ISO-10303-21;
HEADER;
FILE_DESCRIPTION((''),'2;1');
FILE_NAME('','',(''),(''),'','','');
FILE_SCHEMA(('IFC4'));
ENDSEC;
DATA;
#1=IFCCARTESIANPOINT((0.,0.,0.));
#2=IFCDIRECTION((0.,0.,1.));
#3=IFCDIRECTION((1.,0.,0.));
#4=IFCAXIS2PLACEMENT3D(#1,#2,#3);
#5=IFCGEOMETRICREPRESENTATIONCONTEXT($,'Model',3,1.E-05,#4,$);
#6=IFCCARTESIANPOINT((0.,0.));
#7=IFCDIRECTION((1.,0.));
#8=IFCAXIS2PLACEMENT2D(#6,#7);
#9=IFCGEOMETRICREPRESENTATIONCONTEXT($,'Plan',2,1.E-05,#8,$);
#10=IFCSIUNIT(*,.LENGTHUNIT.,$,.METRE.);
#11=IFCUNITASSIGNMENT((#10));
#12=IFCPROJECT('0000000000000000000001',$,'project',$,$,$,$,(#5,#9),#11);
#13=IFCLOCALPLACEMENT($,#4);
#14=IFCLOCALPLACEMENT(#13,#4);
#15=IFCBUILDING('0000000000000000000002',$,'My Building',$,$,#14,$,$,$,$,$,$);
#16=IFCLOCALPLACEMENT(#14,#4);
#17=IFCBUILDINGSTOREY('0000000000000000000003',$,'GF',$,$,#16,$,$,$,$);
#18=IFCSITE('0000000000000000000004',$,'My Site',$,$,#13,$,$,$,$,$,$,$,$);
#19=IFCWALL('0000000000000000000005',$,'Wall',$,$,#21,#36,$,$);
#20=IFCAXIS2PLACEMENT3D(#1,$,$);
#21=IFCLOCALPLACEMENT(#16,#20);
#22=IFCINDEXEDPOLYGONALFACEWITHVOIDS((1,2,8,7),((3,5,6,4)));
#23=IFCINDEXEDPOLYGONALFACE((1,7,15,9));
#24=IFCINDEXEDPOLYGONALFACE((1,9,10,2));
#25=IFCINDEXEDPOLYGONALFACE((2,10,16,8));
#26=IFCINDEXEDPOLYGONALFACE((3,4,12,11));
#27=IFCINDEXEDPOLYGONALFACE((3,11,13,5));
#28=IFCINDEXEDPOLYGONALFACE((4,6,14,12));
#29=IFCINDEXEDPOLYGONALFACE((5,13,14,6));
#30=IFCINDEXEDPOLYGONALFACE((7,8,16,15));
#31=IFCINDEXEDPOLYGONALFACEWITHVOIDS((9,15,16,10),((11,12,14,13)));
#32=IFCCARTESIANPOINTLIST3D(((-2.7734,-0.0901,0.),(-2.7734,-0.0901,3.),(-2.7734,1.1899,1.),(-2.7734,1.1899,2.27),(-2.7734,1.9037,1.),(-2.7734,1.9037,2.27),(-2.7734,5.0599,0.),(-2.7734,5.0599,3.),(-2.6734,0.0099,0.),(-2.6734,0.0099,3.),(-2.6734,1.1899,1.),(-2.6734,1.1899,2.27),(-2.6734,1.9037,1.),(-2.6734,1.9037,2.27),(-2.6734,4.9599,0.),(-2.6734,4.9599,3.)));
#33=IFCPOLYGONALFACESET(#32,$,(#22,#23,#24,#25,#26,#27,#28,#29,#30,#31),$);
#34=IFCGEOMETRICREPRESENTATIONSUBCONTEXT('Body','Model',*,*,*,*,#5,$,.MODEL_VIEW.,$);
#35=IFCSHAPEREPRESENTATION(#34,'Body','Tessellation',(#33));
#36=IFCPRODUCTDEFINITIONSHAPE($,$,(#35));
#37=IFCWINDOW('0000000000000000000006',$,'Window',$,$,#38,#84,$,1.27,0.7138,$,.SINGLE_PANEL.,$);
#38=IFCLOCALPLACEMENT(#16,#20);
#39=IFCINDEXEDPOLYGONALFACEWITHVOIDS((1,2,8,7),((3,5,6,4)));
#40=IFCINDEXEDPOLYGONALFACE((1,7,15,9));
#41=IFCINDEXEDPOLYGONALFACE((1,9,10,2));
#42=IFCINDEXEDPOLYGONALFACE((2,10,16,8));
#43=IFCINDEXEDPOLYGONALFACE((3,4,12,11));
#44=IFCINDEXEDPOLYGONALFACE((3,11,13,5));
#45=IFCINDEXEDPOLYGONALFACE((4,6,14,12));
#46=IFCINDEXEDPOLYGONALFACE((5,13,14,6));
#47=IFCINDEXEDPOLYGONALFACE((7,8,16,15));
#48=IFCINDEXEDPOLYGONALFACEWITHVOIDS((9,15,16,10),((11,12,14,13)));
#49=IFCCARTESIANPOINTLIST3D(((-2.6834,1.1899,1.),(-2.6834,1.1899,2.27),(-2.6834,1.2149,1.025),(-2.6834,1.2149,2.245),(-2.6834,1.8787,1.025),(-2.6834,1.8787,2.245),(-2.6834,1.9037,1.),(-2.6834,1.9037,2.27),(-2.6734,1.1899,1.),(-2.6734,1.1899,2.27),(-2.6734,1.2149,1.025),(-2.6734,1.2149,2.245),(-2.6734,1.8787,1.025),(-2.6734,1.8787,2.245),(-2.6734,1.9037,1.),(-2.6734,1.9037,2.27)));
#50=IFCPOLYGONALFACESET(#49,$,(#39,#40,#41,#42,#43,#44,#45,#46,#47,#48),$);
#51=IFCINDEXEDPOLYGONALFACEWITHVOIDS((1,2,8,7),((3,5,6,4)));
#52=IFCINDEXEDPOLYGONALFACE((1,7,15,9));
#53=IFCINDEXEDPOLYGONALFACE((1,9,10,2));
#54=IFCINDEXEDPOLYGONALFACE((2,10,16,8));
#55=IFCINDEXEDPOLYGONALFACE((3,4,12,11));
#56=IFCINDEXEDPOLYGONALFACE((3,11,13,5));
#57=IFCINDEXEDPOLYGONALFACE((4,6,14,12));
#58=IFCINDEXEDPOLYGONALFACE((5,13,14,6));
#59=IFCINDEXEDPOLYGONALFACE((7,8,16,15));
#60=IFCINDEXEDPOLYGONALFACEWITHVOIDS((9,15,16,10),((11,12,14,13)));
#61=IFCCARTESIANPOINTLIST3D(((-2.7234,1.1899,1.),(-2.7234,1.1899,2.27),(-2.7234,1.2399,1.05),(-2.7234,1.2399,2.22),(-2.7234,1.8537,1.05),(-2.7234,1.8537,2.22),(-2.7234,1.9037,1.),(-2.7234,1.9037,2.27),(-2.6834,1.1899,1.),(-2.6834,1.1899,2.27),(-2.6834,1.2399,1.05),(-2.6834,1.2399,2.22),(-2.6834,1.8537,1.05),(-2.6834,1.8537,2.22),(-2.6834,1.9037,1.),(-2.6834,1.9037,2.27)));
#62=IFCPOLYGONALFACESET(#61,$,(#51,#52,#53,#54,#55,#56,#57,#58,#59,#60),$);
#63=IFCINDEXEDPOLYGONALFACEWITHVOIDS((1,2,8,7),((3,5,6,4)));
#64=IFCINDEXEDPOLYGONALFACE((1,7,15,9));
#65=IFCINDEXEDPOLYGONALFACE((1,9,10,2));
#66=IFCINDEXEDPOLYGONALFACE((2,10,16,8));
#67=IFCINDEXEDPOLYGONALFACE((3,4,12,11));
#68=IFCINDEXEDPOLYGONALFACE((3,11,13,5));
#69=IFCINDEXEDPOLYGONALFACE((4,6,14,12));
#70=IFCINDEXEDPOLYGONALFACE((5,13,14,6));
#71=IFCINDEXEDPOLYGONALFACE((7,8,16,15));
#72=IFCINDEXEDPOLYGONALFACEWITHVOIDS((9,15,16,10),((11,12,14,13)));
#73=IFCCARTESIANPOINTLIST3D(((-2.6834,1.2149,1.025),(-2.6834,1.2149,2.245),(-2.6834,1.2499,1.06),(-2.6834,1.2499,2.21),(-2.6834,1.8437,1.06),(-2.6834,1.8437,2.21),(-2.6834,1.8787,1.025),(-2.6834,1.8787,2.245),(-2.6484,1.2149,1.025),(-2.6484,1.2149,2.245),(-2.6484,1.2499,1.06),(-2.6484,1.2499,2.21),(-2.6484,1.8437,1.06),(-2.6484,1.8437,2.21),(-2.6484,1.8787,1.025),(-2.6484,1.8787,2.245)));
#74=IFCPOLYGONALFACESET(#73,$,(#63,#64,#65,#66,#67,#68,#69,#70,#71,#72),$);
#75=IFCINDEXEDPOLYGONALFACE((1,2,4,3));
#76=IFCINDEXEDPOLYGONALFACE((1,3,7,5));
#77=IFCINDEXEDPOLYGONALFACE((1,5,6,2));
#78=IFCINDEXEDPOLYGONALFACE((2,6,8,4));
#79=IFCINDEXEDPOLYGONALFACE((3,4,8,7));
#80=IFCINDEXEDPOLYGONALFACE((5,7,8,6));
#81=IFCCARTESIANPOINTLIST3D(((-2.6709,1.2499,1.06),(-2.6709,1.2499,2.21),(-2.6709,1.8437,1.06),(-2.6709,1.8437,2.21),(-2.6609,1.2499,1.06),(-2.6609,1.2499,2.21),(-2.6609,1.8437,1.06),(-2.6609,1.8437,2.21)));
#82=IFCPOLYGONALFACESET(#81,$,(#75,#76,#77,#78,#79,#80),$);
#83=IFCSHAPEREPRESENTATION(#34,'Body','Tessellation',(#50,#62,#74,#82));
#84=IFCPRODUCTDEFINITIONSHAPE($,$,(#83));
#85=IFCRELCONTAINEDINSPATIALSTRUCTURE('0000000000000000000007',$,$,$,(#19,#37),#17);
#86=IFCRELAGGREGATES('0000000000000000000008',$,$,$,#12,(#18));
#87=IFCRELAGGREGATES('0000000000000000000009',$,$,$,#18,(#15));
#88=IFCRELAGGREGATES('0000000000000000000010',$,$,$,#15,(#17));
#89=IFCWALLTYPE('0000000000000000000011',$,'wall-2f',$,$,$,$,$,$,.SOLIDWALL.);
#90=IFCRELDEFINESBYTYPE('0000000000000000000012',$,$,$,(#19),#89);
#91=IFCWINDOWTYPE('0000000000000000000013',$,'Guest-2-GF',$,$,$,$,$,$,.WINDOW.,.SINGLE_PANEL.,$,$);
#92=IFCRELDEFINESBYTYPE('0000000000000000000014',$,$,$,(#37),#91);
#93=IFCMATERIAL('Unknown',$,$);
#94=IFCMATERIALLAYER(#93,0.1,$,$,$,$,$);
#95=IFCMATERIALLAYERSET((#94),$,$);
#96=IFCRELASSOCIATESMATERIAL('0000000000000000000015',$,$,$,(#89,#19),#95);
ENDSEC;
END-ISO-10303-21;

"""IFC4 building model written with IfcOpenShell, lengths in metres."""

from ifc_helpers import new_model, entity, si_unit, frame, origin_with_axes, origin_2d_with_axis, place, context, subcontext, project, spatial, line, indexed_curve, outline, extrude, shape, source, transform, mapped, material, layer, layer_set, layer_usage, type_object, type_shapes, element, fill, save


model = new_model("IFC4")

# Units and contexts
model_context = context("Model", 3, precision=1e-05, world=origin_with_axes())
plan_context = context("Plan", 2, precision=1e-05, world=origin_2d_with_axis())
body_context_1 = subcontext(model_context, "Body", "Model", "MODEL_VIEW")
body_context_2 = subcontext(plan_context, "Body", "Plan", "PLAN_VIEW")
ifc_project = project(units=[si_unit("LENGTHUNIT", "METRE")], contexts=[model_context, plan_context])

# Site, building, storey
site_placement = place(None, origin_with_axes())
site = spatial("IfcSite", under=ifc_project, at=site_placement, Name="My Site")
building_placement = place(site_placement, origin_with_axes())
building = spatial("IfcBuilding", under=site, at=building_placement, Name="My Building")
storey_placement = place(building_placement, origin_with_axes())
storey = spatial("IfcBuildingStorey", under=building, at=storey_placement, Name="GF")

# Shared definitions
ifc_material = material(Name="Unknown")

# Shared definitions
ifc_layer_1 = layer(ifc_material, 0.1)
ifc_layer_set_1 = layer_set([ifc_layer_1])
wall_type = type_object("IfcWallType", Name="wall-2f", PredefinedType="SOLIDWALL", material=ifc_layer_set_1)

# Wall, opening, window
ifc_layer_usage_1 = layer_usage(ifc_layer_set_1, "AXIS2", "POSITIVE", 0.0)
wall_1_placement = place(storey_placement, frame((-2.7734, 5.0599, 0.0), z_axis=(0.0, 0.0, 1.0), x_axis=(0.0, -1.0, 0.0)))
wall_1 = element("IfcWall", 1, at=wall_1_placement, inside=storey, type_object=wall_type, material=ifc_layer_usage_1, Name="Wall", context=body_context_1, shape_type="SweptSolid", body=[
    extrude(outline(indexed_curve([(0.0, 0.0), (0.1, 0.1), (5.05, 0.1), (5.15, 0.0)], segments=[line(1, 2, 3, 4, 1)])), origin_with_axes(), (0.0, 0.0, 1.0), 3.0),
])
shared_shape_1 = source(origin_with_axes(), body_context_1, "Body", "SweptSolid", [
    extrude(outline(indexed_curve([(0.0, 0.0), (0.7138, 0.0), (0.7138, 1.27), (0.0, 1.27)], segments=[line(1, 2, 3, 4, 1)])), frame((0.0, -0.6, 0.0), z_axis=(0.0, -1.0, 0.0), x_axis=(1.0, 0.0, 0.0)), (0.0, 0.0, -1.0), 1.2),
])
opening_1_placement = place(wall_1_placement, frame((3.1562, 0.0, 1.0), z_axis=(0.0, 0.0, 1.0), x_axis=(1.0, 0.0, 0.0)))
opening_1 = element("IfcOpeningElement", 2, at=opening_1_placement, cuts=wall_1, PredefinedType="OPENING", context=body_context_1, shape_type="MappedRepresentation", body=[
    mapped(shared_shape_1, transform((0.0, 0.0, 0.0), x_axis=(1.0, 0.0, 0.0), y_axis=(0.0, 1.0, 0.0), z_axis=(0.0, 0.0, 1.0), scale=1.0)),
])
window_type_1 = type_object("IfcWindowType", Name="Guest-2-GF", PartitioningType="SINGLE_PANEL", PredefinedType="WINDOW")
shared_shape_2 = source(origin_with_axes(), body_context_1, "Body", "SweptSolid", [
    extrude(outline(indexed_curve([(0.0, 0.0), (0.7138, 0.0), (0.7138, 1.27), (0.0, 1.27)], segments=[line(1, 2, 3, 4, 1)]), holes=[indexed_curve([(0.025, 0.025), (0.6888, 0.025), (0.6888, 1.245), (0.025, 1.245)], segments=[line(1, 2, 3, 4, 1)])]), frame((0.0, 0.09, 0.0), z_axis=(0.0, -1.0, 0.0), x_axis=(1.0, 0.0, 0.0)), (0.0, 0.0, -1.0), 0.01),
    extrude(outline(indexed_curve([(0.0, 0.0), (0.7138, 0.0), (0.7138, 1.27), (0.0, 1.27)], segments=[line(1, 2, 3, 4, 1)]), holes=[indexed_curve([(0.05, 0.05), (0.6638, 0.05), (0.6638, 1.22), (0.05, 1.22)], segments=[line(1, 2, 3, 4, 1)])]), frame((0.0, 0.05, 0.0), z_axis=(0.0, -1.0, 0.0), x_axis=(1.0, 0.0, 0.0)), (0.0, 0.0, -1.0), 0.04),
    extrude(outline(indexed_curve([(0.0, 0.0), (0.6638, 0.0), (0.6638, 1.22), (0.0, 1.22)], segments=[line(1, 2, 3, 4, 1)]), holes=[indexed_curve([(0.035, 0.035), (0.6288, 0.035), (0.6288, 1.185), (0.035, 1.185)], segments=[line(1, 2, 3, 4, 1)])]), frame((0.025, 0.09, 0.025), z_axis=(0.0, -1.0, 0.0), x_axis=(1.0, 0.0, 0.0)), (0.0, 0.0, -1.0), 0.035),
    extrude(outline(indexed_curve([(0.035, 0.035), (0.6288, 0.035), (0.6288, 1.185), (0.035, 1.185)], segments=[line(1, 2, 3, 4, 1)])), frame((0.025, 0.1025, 0.025), z_axis=(0.0, -1.0, 0.0), x_axis=(1.0, 0.0, 0.0)), (0.0, 0.0, -1.0), 0.01),
])
shared_shape_3 = source(origin_with_axes(), body_context_2, "Body", "Curve2D", [
    entity("IfcIndexedPolyCurve", entity("IfcCartesianPointList2D", [[0.05, 0.05], [0.6638, 0.05]])),
    entity("IfcIndexedPolyCurve", entity("IfcCartesianPointList2D", [[0.0, 0.1], [0.025, 0.1], [0.025, 0.09], [0.05, 0.09], [0.05, 0.05], [0.0, 0.05]]), [entity("IfcLineIndex", [1, 2, 3, 4, 5, 6, 1])]),
    entity("IfcIndexedPolyCurve", entity("IfcCartesianPointList2D", [[0.7138, 0.1], [0.6888, 0.1], [0.6888, 0.09], [0.6638, 0.09], [0.6638, 0.05], [0.7138, 0.05]]), [entity("IfcLineIndex", [1, 2, 3, 4, 5, 6, 1])]),
    entity("IfcIndexedPolyCurve", entity("IfcCartesianPointList2D", [[0.025, 0.09], [0.06, 0.09], [0.06, 0.125], [0.025, 0.125]]), [entity("IfcLineIndex", [1, 2, 3, 4, 1])]),
    entity("IfcIndexedPolyCurve", entity("IfcCartesianPointList2D", [[0.6888, 0.09], [0.6538, 0.09], [0.6538, 0.125], [0.6888, 0.125]]), [entity("IfcLineIndex", [1, 2, 3, 4, 1])]),
    entity("IfcIndexedPolyCurve", entity("IfcCartesianPointList2D", [[0.06, 0.09], [0.6538, 0.09]])),
    entity("IfcIndexedPolyCurve", entity("IfcCartesianPointList2D", [[0.06, 0.125], [0.6538, 0.125]])),
    entity("IfcIndexedPolyCurve", entity("IfcCartesianPointList2D", [[0.06, 0.1075], [0.6538, 0.1075]])),
])
type_shapes(window_type_1, [shared_shape_2, shared_shape_3])
window_1_placement = place(opening_1_placement, frame((0.0, 0.0, 0.0), z_axis=(0.0, 0.0, 1.0), x_axis=(1.0, 0.0, 0.0)))
window_1 = element("IfcWindow", 3, at=window_1_placement, inside=storey, type_object=window_type_1, Name="Window", OverallHeight=1.27, OverallWidth=0.7138, PartitioningType="SINGLE_PANEL", shapes=[
    shape(body_context_1, "Body", "MappedRepresentation", [mapped(shared_shape_2, transform((0.0, 0.0, 0.0), x_axis=(1.0, 0.0, 0.0), y_axis=(0.0, 1.0, 0.0), z_axis=(0.0, 0.0, 1.0), scale=1.0))]),
    shape(body_context_2, "Body", "MappedRepresentation", [mapped(shared_shape_3, transform((0.0, 0.0, 0.0), x_axis=(1.0, 0.0, 0.0), y_axis=(0.0, 1.0, 0.0), z_axis=(0.0, 0.0, 1.0), scale=1.0))]),
])
fill(opening_1, window_1)

save(model, "model.ifc")
